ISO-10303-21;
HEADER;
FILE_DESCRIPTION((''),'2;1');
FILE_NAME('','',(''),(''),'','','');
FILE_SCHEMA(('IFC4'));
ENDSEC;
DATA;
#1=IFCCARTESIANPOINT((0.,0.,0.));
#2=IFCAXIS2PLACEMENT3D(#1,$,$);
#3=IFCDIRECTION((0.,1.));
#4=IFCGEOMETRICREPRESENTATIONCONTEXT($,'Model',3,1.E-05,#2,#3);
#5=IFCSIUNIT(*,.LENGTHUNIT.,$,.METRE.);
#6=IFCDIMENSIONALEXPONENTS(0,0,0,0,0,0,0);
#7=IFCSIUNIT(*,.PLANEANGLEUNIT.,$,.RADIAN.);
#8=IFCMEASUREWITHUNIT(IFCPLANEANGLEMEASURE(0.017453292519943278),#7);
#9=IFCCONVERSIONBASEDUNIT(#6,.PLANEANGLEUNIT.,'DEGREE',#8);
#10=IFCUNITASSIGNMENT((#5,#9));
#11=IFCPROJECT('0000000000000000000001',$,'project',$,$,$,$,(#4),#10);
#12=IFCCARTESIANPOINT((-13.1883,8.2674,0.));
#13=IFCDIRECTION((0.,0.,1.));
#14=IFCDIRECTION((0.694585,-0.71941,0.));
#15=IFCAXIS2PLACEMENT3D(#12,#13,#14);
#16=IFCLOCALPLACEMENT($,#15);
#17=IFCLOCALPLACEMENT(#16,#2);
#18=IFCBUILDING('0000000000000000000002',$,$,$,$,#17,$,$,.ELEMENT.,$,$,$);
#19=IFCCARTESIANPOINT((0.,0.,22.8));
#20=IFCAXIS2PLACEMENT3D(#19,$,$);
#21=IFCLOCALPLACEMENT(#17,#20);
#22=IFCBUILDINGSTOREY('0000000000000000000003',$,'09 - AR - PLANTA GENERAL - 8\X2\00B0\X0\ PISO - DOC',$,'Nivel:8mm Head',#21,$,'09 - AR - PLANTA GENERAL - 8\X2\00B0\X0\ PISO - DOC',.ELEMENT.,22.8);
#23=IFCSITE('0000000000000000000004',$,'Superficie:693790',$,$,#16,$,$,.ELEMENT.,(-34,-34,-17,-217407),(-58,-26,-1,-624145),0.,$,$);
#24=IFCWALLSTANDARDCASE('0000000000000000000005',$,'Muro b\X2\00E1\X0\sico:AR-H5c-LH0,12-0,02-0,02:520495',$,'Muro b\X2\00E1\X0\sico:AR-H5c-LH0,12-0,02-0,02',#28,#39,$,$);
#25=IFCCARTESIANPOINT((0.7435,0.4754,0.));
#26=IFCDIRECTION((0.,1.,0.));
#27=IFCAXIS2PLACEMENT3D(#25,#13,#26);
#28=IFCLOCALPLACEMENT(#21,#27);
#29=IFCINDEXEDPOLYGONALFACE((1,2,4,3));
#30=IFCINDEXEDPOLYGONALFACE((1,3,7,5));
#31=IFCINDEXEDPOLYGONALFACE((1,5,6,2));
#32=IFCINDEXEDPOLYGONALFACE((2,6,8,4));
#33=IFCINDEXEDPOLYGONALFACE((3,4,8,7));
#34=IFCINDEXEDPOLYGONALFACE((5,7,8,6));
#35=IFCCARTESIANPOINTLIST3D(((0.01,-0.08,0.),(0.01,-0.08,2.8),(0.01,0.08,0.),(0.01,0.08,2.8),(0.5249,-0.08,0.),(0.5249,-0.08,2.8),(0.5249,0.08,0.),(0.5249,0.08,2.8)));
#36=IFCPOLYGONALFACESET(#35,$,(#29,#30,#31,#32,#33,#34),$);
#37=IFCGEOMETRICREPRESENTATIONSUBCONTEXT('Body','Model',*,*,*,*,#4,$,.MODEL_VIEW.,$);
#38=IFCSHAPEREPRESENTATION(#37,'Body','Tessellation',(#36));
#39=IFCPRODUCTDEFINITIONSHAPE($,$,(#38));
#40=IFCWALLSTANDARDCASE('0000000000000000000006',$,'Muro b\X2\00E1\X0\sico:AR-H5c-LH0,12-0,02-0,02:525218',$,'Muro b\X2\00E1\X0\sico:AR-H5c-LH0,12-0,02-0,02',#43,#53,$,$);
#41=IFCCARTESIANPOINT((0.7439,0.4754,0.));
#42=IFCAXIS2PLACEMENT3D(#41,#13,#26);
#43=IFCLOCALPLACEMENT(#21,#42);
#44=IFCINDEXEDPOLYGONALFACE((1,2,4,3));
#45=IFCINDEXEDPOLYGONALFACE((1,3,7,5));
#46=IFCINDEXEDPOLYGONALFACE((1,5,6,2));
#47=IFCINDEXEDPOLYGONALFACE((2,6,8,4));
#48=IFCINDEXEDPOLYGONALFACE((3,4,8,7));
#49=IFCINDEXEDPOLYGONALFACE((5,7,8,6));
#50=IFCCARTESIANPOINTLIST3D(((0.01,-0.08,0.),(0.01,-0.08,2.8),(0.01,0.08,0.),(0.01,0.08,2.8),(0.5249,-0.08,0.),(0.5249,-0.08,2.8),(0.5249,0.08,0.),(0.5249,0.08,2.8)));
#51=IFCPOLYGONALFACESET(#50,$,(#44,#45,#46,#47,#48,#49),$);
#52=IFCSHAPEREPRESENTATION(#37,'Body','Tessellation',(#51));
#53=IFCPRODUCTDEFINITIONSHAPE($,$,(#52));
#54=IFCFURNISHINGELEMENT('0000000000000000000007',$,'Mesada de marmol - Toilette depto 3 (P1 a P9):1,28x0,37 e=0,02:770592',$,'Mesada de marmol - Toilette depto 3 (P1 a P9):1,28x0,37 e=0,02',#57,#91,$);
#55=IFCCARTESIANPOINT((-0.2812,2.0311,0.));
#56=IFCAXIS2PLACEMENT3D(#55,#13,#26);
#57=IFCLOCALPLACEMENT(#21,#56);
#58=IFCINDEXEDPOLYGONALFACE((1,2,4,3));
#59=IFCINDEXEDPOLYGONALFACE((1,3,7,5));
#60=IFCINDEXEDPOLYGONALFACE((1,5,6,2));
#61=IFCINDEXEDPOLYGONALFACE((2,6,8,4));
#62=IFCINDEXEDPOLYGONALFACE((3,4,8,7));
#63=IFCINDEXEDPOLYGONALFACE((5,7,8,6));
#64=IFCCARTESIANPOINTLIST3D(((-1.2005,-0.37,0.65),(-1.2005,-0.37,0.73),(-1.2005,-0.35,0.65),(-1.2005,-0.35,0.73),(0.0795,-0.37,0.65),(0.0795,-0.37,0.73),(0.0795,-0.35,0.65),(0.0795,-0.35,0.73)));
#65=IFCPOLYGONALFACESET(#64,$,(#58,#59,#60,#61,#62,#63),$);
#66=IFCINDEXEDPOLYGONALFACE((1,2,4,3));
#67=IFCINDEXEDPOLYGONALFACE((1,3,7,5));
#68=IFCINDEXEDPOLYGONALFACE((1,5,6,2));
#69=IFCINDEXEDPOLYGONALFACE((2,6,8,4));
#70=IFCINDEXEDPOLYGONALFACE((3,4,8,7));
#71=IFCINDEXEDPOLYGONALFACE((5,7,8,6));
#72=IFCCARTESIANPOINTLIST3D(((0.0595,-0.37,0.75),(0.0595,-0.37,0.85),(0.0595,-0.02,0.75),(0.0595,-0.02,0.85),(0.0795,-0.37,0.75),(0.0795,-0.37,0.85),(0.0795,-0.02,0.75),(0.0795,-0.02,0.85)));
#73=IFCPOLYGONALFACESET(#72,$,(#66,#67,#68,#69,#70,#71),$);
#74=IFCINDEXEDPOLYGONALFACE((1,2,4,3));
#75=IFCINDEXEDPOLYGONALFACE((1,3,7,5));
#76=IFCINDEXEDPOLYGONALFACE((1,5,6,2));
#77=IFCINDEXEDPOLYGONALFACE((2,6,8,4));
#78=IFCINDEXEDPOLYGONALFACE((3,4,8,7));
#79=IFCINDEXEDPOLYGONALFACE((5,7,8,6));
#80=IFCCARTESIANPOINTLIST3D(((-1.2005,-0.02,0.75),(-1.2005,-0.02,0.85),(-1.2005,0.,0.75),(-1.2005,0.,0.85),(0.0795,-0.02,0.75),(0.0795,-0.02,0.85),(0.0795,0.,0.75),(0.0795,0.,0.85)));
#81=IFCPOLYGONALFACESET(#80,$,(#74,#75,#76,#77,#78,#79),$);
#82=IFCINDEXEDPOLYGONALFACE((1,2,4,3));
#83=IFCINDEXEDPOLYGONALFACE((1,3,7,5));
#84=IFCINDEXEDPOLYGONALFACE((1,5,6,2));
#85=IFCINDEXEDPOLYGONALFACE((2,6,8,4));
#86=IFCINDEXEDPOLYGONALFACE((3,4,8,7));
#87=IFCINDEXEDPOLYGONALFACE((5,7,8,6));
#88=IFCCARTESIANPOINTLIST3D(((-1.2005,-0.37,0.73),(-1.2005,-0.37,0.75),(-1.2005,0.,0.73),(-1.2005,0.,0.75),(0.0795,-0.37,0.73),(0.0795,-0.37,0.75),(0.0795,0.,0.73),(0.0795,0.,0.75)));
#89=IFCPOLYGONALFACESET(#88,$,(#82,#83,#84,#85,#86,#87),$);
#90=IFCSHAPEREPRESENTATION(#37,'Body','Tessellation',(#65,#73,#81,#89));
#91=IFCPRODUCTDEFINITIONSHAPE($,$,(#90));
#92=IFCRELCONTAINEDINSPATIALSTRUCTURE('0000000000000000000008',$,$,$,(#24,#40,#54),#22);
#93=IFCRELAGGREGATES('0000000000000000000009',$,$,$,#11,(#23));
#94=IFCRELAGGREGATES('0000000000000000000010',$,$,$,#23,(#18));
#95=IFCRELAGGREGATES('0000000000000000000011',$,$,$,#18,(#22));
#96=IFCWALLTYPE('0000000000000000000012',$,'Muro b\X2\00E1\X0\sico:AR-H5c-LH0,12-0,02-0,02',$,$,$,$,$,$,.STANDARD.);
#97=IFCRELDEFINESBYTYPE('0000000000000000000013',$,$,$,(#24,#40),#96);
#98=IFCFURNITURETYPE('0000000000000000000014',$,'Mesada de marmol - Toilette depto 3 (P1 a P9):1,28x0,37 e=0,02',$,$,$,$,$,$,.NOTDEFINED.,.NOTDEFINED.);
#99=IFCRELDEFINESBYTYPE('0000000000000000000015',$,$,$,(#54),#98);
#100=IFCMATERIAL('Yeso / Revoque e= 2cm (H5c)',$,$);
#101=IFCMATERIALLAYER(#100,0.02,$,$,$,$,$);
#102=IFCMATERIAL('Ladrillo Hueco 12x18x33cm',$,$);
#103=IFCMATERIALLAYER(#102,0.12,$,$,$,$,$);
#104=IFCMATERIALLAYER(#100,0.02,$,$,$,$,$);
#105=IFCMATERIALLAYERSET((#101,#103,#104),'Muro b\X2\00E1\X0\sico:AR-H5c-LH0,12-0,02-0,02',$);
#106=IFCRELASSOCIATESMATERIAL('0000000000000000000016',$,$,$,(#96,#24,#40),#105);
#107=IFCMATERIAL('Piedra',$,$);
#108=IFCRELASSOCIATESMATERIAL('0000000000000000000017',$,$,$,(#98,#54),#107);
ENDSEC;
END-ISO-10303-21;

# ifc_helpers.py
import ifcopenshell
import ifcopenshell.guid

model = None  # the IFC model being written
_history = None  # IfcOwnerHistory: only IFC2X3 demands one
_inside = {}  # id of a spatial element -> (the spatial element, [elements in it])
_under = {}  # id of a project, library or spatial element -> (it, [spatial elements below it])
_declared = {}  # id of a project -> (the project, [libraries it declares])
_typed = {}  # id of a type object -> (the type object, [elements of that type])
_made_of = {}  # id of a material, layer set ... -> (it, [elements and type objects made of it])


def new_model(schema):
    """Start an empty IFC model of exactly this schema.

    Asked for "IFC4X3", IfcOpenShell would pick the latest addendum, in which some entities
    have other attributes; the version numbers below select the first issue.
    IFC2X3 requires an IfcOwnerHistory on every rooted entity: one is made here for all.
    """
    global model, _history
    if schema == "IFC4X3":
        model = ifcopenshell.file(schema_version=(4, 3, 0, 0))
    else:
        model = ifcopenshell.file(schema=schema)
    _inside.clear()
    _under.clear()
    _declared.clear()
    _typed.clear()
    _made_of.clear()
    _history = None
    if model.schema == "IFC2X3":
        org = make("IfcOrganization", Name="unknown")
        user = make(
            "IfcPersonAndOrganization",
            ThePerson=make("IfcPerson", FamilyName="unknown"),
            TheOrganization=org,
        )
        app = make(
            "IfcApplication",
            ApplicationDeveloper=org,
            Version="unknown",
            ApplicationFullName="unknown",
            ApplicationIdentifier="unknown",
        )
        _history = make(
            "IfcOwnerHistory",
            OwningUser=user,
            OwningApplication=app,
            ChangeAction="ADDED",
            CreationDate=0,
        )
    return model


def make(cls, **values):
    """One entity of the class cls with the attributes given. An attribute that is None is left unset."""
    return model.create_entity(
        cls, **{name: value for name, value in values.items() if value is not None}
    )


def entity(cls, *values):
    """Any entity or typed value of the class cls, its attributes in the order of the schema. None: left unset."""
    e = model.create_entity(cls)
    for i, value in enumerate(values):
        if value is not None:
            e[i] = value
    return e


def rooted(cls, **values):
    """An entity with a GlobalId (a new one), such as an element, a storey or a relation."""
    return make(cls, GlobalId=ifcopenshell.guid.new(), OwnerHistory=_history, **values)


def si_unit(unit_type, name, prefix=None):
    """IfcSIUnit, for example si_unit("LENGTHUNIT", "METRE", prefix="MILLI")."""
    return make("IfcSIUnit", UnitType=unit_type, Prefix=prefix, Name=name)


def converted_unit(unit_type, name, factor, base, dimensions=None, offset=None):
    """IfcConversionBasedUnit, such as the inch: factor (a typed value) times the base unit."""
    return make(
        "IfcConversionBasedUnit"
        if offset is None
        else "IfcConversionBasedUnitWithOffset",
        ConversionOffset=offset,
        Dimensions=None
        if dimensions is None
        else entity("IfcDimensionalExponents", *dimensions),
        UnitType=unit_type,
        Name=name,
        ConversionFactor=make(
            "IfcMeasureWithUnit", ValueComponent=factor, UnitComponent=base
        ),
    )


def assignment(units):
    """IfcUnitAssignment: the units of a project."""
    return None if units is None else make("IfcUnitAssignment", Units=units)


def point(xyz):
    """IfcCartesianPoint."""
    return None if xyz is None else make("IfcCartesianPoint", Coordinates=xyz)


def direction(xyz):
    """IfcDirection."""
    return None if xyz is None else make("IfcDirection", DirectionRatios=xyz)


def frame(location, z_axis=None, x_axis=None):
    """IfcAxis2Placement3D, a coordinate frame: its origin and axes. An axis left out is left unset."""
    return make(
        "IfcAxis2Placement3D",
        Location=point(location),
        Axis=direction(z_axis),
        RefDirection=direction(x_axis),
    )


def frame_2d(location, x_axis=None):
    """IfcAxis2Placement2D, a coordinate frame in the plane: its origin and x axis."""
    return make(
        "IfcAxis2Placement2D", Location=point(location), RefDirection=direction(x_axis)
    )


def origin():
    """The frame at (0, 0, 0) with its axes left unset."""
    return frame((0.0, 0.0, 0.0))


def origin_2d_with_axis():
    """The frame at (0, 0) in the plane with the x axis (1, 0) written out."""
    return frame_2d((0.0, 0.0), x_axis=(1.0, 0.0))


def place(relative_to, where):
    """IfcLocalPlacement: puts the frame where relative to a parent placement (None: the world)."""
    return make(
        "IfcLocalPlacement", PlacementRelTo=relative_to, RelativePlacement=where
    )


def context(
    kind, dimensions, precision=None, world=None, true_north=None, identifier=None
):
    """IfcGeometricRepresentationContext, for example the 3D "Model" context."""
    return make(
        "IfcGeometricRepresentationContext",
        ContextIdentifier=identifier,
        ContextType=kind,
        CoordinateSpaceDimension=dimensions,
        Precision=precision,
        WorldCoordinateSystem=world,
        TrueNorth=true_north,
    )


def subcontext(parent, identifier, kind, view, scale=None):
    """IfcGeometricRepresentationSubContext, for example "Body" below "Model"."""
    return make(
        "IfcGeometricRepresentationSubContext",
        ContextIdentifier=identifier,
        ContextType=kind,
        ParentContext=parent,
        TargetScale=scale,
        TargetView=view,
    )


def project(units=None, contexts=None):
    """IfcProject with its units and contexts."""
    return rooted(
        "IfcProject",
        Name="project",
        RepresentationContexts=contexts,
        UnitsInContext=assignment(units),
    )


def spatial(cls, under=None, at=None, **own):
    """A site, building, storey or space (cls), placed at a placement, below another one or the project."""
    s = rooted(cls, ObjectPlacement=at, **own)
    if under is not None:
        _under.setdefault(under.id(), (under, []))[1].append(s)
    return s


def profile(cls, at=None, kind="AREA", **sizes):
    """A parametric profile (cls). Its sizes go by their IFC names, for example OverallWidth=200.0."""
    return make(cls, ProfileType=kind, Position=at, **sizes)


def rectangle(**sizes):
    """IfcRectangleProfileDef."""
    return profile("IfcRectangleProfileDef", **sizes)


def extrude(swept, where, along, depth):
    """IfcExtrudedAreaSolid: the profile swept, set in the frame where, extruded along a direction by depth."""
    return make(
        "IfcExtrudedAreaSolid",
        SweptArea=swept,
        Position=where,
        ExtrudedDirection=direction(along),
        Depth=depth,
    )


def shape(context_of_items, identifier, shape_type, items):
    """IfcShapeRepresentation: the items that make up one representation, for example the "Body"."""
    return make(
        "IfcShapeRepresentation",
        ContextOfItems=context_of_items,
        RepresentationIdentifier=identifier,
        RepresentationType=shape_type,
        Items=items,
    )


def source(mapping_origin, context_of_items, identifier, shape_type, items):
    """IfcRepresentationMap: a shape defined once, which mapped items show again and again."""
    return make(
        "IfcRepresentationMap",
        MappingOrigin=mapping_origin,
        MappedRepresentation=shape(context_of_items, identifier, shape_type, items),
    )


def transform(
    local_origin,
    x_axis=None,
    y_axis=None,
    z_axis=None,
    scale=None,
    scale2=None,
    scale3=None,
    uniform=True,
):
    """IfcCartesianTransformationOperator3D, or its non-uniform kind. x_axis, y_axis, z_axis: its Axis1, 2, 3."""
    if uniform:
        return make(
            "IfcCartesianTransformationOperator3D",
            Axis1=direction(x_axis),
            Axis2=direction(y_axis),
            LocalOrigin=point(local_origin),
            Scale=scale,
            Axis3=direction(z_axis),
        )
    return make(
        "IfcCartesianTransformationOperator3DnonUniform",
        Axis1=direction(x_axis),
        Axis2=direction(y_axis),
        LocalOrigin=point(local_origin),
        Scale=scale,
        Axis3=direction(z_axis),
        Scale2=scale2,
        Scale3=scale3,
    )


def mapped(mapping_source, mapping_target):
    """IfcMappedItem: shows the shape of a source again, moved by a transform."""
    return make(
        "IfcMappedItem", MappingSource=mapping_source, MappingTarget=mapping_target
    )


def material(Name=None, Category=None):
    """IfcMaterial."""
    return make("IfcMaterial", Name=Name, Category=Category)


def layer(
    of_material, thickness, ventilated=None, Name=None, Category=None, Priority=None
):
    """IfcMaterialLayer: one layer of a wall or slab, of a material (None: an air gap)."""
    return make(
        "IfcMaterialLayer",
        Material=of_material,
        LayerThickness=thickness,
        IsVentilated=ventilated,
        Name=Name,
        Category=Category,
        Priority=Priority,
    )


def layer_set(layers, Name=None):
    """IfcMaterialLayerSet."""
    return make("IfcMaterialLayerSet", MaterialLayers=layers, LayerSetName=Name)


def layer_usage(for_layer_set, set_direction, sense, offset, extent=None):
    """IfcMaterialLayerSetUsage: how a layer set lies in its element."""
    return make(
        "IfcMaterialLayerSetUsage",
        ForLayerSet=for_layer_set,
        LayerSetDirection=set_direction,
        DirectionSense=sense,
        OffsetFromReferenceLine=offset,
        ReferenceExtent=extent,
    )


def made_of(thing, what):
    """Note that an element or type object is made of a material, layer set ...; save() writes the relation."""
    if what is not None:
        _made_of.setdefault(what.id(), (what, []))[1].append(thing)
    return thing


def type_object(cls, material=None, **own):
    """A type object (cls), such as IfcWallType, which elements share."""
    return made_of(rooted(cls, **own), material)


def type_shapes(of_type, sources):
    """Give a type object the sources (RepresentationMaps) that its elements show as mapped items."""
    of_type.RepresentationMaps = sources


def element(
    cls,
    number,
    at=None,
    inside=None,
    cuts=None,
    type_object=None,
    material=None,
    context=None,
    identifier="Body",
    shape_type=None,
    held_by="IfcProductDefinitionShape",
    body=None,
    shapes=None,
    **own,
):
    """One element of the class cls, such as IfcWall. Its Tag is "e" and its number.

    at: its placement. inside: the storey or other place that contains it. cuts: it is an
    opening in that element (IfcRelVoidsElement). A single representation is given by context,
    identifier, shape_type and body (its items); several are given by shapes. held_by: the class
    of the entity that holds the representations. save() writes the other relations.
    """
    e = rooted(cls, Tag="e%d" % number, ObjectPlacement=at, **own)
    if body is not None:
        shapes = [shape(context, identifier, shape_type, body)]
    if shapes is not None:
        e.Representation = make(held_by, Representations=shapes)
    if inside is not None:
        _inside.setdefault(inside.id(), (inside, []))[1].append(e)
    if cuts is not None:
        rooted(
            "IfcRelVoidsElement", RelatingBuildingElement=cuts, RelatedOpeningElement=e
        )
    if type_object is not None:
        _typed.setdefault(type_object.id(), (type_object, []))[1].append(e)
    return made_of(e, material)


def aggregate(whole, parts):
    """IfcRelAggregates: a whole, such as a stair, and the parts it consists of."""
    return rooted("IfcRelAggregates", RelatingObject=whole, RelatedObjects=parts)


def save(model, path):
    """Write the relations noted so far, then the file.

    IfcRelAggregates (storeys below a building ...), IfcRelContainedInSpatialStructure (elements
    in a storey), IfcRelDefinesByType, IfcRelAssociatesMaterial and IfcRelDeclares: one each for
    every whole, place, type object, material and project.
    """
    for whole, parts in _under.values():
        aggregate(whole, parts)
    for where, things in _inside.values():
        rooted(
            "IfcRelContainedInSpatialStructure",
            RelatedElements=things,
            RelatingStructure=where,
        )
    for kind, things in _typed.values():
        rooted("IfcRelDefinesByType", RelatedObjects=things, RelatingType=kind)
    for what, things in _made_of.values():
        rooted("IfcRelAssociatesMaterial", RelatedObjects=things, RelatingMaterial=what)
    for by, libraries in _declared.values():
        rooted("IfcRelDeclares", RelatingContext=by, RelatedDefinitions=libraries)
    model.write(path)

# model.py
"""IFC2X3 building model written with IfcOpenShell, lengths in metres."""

from ifc_helpers import new_model, entity, si_unit, converted_unit, direction, frame, frame_2d, origin, origin_2d_with_axis, place, context, subcontext, project, spatial, rectangle, extrude, source, transform, mapped, material, layer, layer_set, layer_usage, type_object, type_shapes, element, save


model = new_model("IFC2X3")

# Units and contexts
model_context = context("Model", 3, precision=1e-05, world=origin(), true_north=direction((0.0, 1.0)))
body_context = subcontext(model_context, "Body", "Model", "MODEL_VIEW")
ifc_project = project(units=[si_unit("LENGTHUNIT", "METRE"), converted_unit("PLANEANGLEUNIT", "DEGREE", entity("IfcPlaneAngleMeasure", 0.017453292519943278), si_unit("PLANEANGLEUNIT", "RADIAN"), dimensions=[0, 0, 0, 0, 0, 0, 0])], contexts=[model_context])

# Site, building, storey
site_placement = place(None, frame((-13.1883, 8.2674, 0.0), z_axis=(0.0, 0.0, 1.0), x_axis=(0.694585, -0.71941, 0.0)))
site = spatial("IfcSite", under=ifc_project, at=site_placement, Name="Superficie:693790", CompositionType="ELEMENT", RefLatitude=(-34, -34, -17, -217407), RefLongitude=(-58, -26, -1, -624145), RefElevation=0.0)
building_placement = place(site_placement, origin())
building = spatial("IfcBuilding", under=site, at=building_placement, CompositionType="ELEMENT")
storey_placement = place(building_placement, frame((0.0, 0.0, 22.8)))
storey = spatial("IfcBuildingStorey", under=building, at=storey_placement, Name="09 - AR - PLANTA GENERAL - 8° PISO - DOC", ObjectType="Nivel:8mm Head", LongName="09 - AR - PLANTA GENERAL - 8° PISO - DOC", CompositionType="ELEMENT", Elevation=22.8)

# Walls
ifc_material_1 = material(Name="Yeso / Revoque e= 2cm (H5c)")
ifc_layer_1 = layer(ifc_material_1, 0.02)
ifc_material_2 = material(Name="Ladrillo Hueco 12x18x33cm")
ifc_layer_2 = layer(ifc_material_2, 0.12)
ifc_layer_3 = layer(ifc_material_1, 0.02)
ifc_layer_set_1 = layer_set([ifc_layer_1, ifc_layer_2, ifc_layer_3], Name="Muro básico:AR-H5c-LH0,12-0,02-0,02")
wall_type_1 = type_object("IfcWallType", Name="Muro básico:AR-H5c-LH0,12-0,02-0,02", PredefinedType="STANDARD", material=ifc_layer_set_1)
ifc_layer_usage_1 = layer_usage(ifc_layer_set_1, "AXIS2", "NEGATIVE", 0.08)
wall_1_placement = place(storey_placement, frame((0.7435, 0.4754, 0.0), z_axis=(0.0, 0.0, 1.0), x_axis=(0.0, 1.0, 0.0)))
element("IfcWallStandardCase", 1, at=wall_1_placement, inside=storey, type_object=wall_type_1, material=ifc_layer_usage_1, Name="Muro básico:AR-H5c-LH0,12-0,02-0,02:520495", ObjectType="Muro básico:AR-H5c-LH0,12-0,02-0,02", context=body_context, shape_type="SweptSolid", body=[
    extrude(rectangle(XDim=0.5149, YDim=0.16, at=frame_2d((0.2675, 0.0), x_axis=(-1.0, 0.0))), origin(), (0.0, 0.0, 1.0), 2.8),
])
ifc_layer_usage_2 = layer_usage(ifc_layer_set_1, "AXIS2", "NEGATIVE", 0.08)
wall_2_placement = place(storey_placement, frame((0.7439, 0.4754, 0.0), z_axis=(0.0, 0.0, 1.0), x_axis=(0.0, 1.0, 0.0)))
element("IfcWallStandardCase", 2, at=wall_2_placement, inside=storey, type_object=wall_type_1, material=ifc_layer_usage_2, Name="Muro básico:AR-H5c-LH0,12-0,02-0,02:525218", ObjectType="Muro básico:AR-H5c-LH0,12-0,02-0,02", context=body_context, shape_type="SweptSolid", body=[
    extrude(rectangle(XDim=0.5149, YDim=0.16, at=frame_2d((0.2675, 0.0), x_axis=(-1.0, 0.0))), origin(), (0.0, 0.0, 1.0), 2.8),
])

# Furnishing element
ifc_material_3 = material(Name="Piedra")
furniture_type_1 = type_object("IfcFurnitureType", Name="Mesada de marmol - Toilette depto 3 (P1 a P9):1,28x0,37 e=0,02", AssemblyPlace="NOTDEFINED", material=ifc_material_3)
shared_shape_1 = source(origin(), body_context, "Body", "SweptSolid", [
    extrude(rectangle(XDim=0.02, YDim=1.28, at=origin_2d_with_axis()), frame((-0.5605, -0.36, 0.65), z_axis=(0.0, 0.0, 1.0), x_axis=(0.0, 1.0, 0.0)), (0.0, 0.0, 1.0), 0.08),
    extrude(rectangle(XDim=0.02, YDim=0.35, at=frame_2d((0.0, 0.0), x_axis=(1.0, 0.0))), frame((0.0695, -0.195, 0.75), z_axis=(0.0, 0.0, 1.0), x_axis=(-1.0, 0.0, 0.0)), (0.0, 0.0, 1.0), 0.1),
    extrude(rectangle(XDim=0.02, YDim=1.28, at=origin_2d_with_axis()), frame((-0.5605, -0.01, 0.75), z_axis=(0.0, 0.0, 1.0), x_axis=(0.0, -1.0, 0.0)), (0.0, 0.0, 1.0), 0.1),
    extrude(rectangle(XDim=1.28, YDim=0.37, at=frame_2d((0.0, 0.0), x_axis=(1.0, 0.0))), frame((-0.5605, -0.185, 0.73), z_axis=(0.0, 0.0, 1.0), x_axis=(-1.0, 0.0, 0.0)), (0.0, 0.0, 1.0), 0.02),
])
type_shapes(furniture_type_1, [shared_shape_1])
furnishing_1_placement = place(storey_placement, frame((-0.2812, 2.0311, 0.0), z_axis=(0.0, 0.0, 1.0), x_axis=(0.0, 1.0, 0.0)))
element("IfcFurnishingElement", 3, at=furnishing_1_placement, inside=storey, type_object=furniture_type_1, material=ifc_material_3, Name="Mesada de marmol - Toilette depto 3 (P1 a P9):1,28x0,37 e=0,02:770592", ObjectType="Mesada de marmol - Toilette depto 3 (P1 a P9):1,28x0,37 e=0,02", context=body_context, shape_type="MappedRepresentation", body=[
    mapped(shared_shape_1, transform((0.0, 0.0, 0.0), scale=1.0)),
])

save(model, "model.ifc")
